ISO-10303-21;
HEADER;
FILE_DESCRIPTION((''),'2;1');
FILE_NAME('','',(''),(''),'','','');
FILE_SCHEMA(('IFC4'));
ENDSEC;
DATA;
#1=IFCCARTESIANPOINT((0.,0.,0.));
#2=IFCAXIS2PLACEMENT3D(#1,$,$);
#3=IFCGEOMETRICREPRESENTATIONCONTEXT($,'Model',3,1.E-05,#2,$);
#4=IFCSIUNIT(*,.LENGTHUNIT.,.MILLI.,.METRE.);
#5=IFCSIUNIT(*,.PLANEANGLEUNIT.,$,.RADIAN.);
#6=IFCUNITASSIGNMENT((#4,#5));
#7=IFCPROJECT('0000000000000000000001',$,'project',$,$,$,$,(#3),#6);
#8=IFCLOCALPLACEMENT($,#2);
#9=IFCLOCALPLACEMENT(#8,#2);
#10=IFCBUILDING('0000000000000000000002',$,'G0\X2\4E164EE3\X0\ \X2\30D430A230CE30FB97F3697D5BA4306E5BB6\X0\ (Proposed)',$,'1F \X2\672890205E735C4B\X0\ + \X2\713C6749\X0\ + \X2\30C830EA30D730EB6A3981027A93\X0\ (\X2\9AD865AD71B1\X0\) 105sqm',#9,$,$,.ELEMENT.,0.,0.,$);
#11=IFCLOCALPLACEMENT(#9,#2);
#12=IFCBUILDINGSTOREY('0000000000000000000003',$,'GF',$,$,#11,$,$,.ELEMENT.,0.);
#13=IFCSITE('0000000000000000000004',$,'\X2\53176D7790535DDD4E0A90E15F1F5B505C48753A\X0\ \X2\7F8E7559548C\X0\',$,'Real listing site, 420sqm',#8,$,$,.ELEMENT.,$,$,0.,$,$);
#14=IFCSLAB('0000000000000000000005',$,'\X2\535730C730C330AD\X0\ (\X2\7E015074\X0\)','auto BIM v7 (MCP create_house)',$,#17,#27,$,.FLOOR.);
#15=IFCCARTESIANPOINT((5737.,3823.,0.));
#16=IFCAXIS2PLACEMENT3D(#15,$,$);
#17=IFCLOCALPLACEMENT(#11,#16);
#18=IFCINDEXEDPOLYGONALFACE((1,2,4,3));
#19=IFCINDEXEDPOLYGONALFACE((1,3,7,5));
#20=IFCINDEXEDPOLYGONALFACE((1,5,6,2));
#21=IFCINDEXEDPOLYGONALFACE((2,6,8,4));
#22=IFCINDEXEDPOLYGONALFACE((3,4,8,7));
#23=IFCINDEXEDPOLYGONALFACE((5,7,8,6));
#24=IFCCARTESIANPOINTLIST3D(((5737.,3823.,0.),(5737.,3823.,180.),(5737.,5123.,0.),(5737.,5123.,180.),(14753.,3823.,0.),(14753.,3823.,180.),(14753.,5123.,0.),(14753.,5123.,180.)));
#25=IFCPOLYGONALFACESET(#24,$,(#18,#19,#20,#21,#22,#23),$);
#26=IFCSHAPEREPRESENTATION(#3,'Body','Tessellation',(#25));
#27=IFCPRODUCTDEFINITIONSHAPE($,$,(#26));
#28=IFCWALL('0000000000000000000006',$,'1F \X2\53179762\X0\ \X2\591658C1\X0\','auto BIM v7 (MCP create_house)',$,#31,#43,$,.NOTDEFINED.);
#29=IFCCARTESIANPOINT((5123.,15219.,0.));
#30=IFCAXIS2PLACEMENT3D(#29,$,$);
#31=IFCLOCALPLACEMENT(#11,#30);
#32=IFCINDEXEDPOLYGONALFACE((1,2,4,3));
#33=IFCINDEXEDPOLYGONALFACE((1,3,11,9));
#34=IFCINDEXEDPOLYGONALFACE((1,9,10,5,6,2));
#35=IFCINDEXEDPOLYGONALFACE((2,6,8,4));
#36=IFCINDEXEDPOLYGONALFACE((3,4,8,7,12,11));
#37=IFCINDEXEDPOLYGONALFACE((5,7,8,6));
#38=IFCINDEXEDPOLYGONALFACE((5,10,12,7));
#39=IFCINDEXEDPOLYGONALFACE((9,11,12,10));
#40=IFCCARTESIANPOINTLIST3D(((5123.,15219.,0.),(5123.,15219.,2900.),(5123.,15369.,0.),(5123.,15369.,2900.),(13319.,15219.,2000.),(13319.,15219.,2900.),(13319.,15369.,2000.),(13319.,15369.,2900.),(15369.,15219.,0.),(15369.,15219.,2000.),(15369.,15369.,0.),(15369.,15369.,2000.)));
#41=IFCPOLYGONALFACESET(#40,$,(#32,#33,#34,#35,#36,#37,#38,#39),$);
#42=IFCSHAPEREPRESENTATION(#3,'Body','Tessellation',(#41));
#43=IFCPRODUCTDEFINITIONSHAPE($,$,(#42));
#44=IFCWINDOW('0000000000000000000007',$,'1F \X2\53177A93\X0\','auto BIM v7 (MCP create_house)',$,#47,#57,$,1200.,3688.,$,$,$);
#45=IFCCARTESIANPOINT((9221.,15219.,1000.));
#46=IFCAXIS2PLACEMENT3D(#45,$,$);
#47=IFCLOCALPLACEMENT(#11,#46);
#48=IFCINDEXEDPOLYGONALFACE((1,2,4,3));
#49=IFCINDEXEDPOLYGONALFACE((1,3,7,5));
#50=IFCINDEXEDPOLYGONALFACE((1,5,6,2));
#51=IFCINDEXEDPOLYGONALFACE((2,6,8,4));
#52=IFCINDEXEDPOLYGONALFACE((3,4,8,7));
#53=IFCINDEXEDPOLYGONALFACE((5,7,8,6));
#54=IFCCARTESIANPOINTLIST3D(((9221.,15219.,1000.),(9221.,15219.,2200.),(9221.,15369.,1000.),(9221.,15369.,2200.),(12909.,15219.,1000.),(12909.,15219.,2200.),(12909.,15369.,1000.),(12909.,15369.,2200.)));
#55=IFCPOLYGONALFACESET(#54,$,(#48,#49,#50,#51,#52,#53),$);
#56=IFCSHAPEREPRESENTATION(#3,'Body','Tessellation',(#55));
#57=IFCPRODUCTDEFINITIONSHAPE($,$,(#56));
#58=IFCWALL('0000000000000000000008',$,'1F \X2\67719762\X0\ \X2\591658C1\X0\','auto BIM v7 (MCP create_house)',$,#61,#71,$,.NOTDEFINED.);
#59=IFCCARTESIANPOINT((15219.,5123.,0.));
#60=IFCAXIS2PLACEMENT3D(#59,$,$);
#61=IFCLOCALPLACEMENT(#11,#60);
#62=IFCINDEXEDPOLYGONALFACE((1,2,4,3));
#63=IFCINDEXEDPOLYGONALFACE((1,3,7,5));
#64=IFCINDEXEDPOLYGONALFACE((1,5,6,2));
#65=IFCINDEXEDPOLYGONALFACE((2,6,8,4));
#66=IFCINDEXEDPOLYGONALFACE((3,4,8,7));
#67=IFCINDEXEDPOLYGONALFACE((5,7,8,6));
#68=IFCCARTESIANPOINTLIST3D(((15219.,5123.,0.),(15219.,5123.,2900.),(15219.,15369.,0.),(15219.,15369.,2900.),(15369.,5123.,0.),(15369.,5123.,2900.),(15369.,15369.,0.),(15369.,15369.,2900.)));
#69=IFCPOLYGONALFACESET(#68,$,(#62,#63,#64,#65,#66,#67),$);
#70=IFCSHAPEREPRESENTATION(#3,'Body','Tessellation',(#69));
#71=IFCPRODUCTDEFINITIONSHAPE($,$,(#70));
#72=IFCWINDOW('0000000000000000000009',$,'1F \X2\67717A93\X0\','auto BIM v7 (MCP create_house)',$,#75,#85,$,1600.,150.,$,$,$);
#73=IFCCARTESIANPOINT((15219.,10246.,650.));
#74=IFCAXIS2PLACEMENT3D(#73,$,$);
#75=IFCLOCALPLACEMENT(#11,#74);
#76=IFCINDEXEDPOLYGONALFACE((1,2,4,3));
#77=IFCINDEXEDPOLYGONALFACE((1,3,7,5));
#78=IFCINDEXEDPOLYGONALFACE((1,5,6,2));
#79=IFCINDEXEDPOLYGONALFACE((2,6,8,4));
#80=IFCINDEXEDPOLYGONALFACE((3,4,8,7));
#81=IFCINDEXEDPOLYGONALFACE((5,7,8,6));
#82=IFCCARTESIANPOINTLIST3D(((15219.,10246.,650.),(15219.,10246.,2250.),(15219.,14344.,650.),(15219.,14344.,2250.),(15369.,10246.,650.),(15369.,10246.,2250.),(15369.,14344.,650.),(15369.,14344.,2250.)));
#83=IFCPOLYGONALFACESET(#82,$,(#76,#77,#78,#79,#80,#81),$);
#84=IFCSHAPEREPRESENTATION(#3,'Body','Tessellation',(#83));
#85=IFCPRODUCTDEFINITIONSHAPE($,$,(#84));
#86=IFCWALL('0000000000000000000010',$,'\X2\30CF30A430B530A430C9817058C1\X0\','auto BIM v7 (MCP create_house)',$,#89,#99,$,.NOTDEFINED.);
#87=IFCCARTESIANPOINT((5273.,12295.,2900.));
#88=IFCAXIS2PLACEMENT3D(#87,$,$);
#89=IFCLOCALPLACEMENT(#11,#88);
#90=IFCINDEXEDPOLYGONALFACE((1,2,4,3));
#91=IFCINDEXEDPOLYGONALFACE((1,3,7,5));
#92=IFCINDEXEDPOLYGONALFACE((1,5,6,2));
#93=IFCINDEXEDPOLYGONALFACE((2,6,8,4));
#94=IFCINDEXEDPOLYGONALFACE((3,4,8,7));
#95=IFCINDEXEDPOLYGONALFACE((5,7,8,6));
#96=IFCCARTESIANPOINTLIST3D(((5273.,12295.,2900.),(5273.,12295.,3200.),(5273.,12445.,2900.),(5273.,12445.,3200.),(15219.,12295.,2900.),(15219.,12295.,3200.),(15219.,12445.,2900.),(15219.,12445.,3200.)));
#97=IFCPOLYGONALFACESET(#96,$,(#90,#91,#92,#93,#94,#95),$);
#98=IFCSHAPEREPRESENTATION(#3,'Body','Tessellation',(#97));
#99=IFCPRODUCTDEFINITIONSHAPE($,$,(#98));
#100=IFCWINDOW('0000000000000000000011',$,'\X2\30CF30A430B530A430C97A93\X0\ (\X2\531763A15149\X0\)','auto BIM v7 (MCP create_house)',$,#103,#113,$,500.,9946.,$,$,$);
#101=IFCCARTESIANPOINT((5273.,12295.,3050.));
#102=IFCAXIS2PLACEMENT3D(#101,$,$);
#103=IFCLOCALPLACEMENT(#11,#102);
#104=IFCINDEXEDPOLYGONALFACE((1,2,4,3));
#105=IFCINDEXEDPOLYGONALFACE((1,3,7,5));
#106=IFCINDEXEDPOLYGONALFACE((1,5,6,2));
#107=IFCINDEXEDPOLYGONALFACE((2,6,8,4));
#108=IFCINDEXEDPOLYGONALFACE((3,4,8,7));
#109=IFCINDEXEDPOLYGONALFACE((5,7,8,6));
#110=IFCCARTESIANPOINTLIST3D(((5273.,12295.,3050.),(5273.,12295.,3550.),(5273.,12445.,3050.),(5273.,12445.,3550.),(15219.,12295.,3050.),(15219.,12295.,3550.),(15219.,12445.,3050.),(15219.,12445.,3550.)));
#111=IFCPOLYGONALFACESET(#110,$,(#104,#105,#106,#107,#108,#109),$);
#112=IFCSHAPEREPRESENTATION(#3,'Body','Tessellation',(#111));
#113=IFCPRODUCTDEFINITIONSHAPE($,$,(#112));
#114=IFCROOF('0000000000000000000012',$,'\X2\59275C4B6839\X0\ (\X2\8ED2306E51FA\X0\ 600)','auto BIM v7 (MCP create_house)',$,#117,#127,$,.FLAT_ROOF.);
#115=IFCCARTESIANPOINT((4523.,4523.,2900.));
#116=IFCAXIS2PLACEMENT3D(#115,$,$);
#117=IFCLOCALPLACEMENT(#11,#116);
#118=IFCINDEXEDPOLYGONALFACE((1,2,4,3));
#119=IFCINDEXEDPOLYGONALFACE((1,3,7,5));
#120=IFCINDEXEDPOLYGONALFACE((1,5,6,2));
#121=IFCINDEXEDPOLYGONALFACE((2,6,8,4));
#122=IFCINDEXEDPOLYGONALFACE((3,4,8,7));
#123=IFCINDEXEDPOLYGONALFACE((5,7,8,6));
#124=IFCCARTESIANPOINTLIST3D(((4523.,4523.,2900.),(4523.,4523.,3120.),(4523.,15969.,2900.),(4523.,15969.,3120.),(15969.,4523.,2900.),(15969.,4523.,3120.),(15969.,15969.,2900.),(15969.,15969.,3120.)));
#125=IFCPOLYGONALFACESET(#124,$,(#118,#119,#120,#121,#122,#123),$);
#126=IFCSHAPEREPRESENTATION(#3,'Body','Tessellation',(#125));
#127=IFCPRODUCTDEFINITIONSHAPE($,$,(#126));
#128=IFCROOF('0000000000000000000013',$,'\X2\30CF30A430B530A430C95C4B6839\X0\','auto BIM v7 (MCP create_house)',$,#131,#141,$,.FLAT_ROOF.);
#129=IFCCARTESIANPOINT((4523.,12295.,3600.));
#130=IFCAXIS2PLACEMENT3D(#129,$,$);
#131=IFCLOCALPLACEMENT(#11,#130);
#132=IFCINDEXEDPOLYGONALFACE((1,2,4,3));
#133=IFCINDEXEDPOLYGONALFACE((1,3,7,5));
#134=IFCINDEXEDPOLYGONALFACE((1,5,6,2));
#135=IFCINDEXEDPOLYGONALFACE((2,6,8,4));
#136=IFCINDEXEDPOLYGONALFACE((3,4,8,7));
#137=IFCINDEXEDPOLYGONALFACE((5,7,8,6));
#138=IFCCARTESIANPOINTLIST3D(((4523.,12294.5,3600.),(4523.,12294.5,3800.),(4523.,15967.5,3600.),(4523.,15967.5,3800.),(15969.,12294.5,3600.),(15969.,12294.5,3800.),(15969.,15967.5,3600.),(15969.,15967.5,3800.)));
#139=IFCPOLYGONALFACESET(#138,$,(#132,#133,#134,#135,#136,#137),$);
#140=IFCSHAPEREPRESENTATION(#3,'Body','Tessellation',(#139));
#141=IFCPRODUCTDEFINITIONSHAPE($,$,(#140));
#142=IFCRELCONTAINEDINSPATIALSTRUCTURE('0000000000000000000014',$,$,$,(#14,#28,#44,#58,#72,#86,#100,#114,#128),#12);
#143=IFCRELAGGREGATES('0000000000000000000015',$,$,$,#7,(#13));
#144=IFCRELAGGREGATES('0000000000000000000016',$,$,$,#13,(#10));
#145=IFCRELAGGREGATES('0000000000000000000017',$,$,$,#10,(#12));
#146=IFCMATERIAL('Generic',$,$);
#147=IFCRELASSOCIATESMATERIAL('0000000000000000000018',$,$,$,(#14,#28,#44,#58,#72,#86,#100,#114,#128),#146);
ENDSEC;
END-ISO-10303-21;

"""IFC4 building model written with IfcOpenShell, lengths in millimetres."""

from ifc_helpers import new_model, si_unit, frame, frame_2d, origin, place, context, project, spatial, rectangle, extrude, material, element, fill, save


model = new_model("IFC4")

# Units and contexts
model_context = context("Model", 3, precision=1e-05, world=origin())
ifc_project = project(units=[si_unit("LENGTHUNIT", "METRE", prefix="MILLI"), si_unit("PLANEANGLEUNIT", "RADIAN")], contexts=[model_context])

# Site, building, storey
site_placement = place(None, origin())
site = spatial("IfcSite", under=ifc_project, at=site_placement, Name="北海道川上郡弟子屈町 美留和", ObjectType="Real listing site, 420sqm", CompositionType="ELEMENT", RefElevation=0.0)
building_placement = place(site_placement, origin())
building = spatial("IfcBuilding", under=site, at=building_placement, Name="G0世代 ピアノ・音楽室の家 (Proposed)", ObjectType="1F 木造平屋 + 焼杉 + トリプル樹脂窓 (高断熱) 105sqm", CompositionType="ELEMENT", ElevationOfRefHeight=0.0, ElevationOfTerrain=0.0)
storey_placement = place(building_placement, origin())
storey = spatial("IfcBuildingStorey", under=building, at=storey_placement, Name="GF", CompositionType="ELEMENT", Elevation=0.0)

# Slab
ifc_material = material(Name="Generic")
slab_1_placement = place(storey_placement, frame((5737.0, 3823.0, 0.0)))
element("IfcSlab", 1, at=slab_1_placement, inside=storey, material=ifc_material, Name="南デッキ (縁側)", Description="auto BIM v7 (MCP create_house)", PredefinedType="FLOOR", context=model_context, shape_type="SweptSolid", body=[
    extrude(rectangle(XDim=9016.0, YDim=1300.0, at=frame_2d((4508.0, 650.0))), frame((5737.0, 3823.0, 0.0)), (0.0, 0.0, 1.0), 180.0),
])

# Walls, openings, windows
wall_1_placement = place(storey_placement, frame((5123.0, 15219.0, 0.0)))
wall_1 = element("IfcWall", 2, at=wall_1_placement, inside=storey, material=ifc_material, Name="1F 北面 外壁", Description="auto BIM v7 (MCP create_house)", PredefinedType="NOTDEFINED", context=model_context, shape_type="SweptSolid", body=[
    extrude(rectangle(XDim=10246.0, YDim=150.0, at=frame_2d((5123.0, 75.0))), frame((5123.0, 15219.0, 0.0)), (0.0, 0.0, 1.0), 2900.0),
])
opening_1_placement = place(storey_placement, frame((9221.0, 15219.0, 1000.0)))
opening_1 = element("IfcOpeningElement", 3, at=opening_1_placement, cuts=wall_1, PredefinedType="NOTDEFINED", context=model_context, shape_type="SweptSolid", body=[
    extrude(rectangle(XDim=3688.0, YDim=150.0, at=frame_2d((1844.0, 75.0))), frame((9221.0, 15219.0, 1000.0)), (0.0, 0.0, 1.0), 1200.0),
])
window_1_placement = place(storey_placement, frame((9221.0, 15219.0, 1000.0)))
window_1 = element("IfcWindow", 4, at=window_1_placement, inside=storey, material=ifc_material, Name="1F 北窓", Description="auto BIM v7 (MCP create_house)", OverallHeight=1200.0, OverallWidth=3688.0, context=model_context, shape_type="SweptSolid", body=[
    extrude(rectangle(XDim=3688.0, YDim=150.0, at=frame_2d((1844.0, 75.0))), frame((9221.0, 15219.0, 1000.0)), (0.0, 0.0, 1.0), 1200.0),
])
fill(opening_1, window_1)
wall_2_placement = place(storey_placement, frame((15219.0, 5123.0, 0.0)))
wall_2 = element("IfcWall", 5, at=wall_2_placement, inside=storey, material=ifc_material, Name="1F 東面 外壁", Description="auto BIM v7 (MCP create_house)", PredefinedType="NOTDEFINED", context=model_context, shape_type="SweptSolid", body=[
    extrude(rectangle(XDim=150.0, YDim=10246.0, at=frame_2d((75.0, 5123.0))), frame((15219.0, 5123.0, 0.0)), (0.0, 0.0, 1.0), 2900.0),
])
opening_2_placement = place(storey_placement, frame((15219.0, 10246.0, 650.0)))
opening_2 = element("IfcOpeningElement", 6, at=opening_2_placement, cuts=wall_2, PredefinedType="NOTDEFINED", context=model_context, shape_type="SweptSolid", body=[
    extrude(rectangle(XDim=150.0, YDim=4098.0, at=frame_2d((75.0, 2049.0))), frame((15219.0, 10246.0, 650.0)), (0.0, 0.0, 1.0), 1600.0),
])
window_2_placement = place(storey_placement, frame((15219.0, 10246.0, 650.0)))
window_2 = element("IfcWindow", 7, at=window_2_placement, inside=storey, material=ifc_material, Name="1F 東窓", Description="auto BIM v7 (MCP create_house)", OverallHeight=1600.0, OverallWidth=150.0, context=model_context, shape_type="SweptSolid", body=[
    extrude(rectangle(XDim=150.0, YDim=4098.0, at=frame_2d((75.0, 2049.0))), frame((15219.0, 10246.0, 650.0)), (0.0, 0.0, 1.0), 1600.0),
])
fill(opening_2, window_2)

# Wall, opening, window
wall_3_placement = place(storey_placement, frame((5273.0, 12295.0, 2900.0)))
wall_3 = element("IfcWall", 8, at=wall_3_placement, inside=storey, material=ifc_material, Name="ハイサイド腰壁", Description="auto BIM v7 (MCP create_house)", PredefinedType="NOTDEFINED", context=model_context, shape_type="SweptSolid", body=[
    extrude(rectangle(XDim=9946.0, YDim=150.0, at=frame_2d((4973.0, 75.0))), frame((5273.0, 12295.0, 2900.0)), (0.0, 0.0, 1.0), 700.0),
])
opening_3_placement = place(storey_placement, frame((5273.0, 12295.0, 3050.0)))
opening_3 = element("IfcOpeningElement", 9, at=opening_3_placement, cuts=wall_3, PredefinedType="NOTDEFINED", context=model_context, shape_type="SweptSolid", body=[
    extrude(rectangle(XDim=9946.0, YDim=150.0, at=frame_2d((4973.0, 75.0))), frame((5273.0, 12295.0, 3050.0)), (0.0, 0.0, 1.0), 500.0),
])
window_3_placement = place(storey_placement, frame((5273.0, 12295.0, 3050.0)))
window_3 = element("IfcWindow", 10, at=window_3_placement, inside=storey, material=ifc_material, Name="ハイサイド窓 (北採光)", Description="auto BIM v7 (MCP create_house)", OverallHeight=500.0, OverallWidth=9946.0, context=model_context, shape_type="SweptSolid", body=[
    extrude(rectangle(XDim=9946.0, YDim=150.0, at=frame_2d((4973.0, 75.0))), frame((5273.0, 12295.0, 3050.0)), (0.0, 0.0, 1.0), 500.0),
])
fill(opening_3, window_3)

# Roofs
roof_1_placement = place(storey_placement, frame((4523.0, 4523.0, 2900.0)))
element("IfcRoof", 11, at=roof_1_placement, inside=storey, material=ifc_material, Name="大屋根 (軒の出 600)", Description="auto BIM v7 (MCP create_house)", PredefinedType="FLAT_ROOF", context=model_context, shape_type="SweptSolid", body=[
    extrude(rectangle(XDim=11446.0, YDim=11446.0, at=frame_2d((5723.0, 5723.0))), frame((4523.0, 4523.0, 2900.0)), (0.0, 0.0, 1.0), 220.0),
])
roof_2_placement = place(storey_placement, frame((4523.0, 12295.0, 3600.0)))
element("IfcRoof", 12, at=roof_2_placement, inside=storey, material=ifc_material, Name="ハイサイド屋根", Description="auto BIM v7 (MCP create_house)", PredefinedType="FLAT_ROOF", context=model_context, shape_type="SweptSolid", body=[
    extrude(rectangle(XDim=11446.0, YDim=3673.0, at=frame_2d((5723.0, 1836.0))), frame((4523.0, 12295.0, 3600.0)), (0.0, 0.0, 1.0), 200.0),
])

save(model, "model.ifc")
